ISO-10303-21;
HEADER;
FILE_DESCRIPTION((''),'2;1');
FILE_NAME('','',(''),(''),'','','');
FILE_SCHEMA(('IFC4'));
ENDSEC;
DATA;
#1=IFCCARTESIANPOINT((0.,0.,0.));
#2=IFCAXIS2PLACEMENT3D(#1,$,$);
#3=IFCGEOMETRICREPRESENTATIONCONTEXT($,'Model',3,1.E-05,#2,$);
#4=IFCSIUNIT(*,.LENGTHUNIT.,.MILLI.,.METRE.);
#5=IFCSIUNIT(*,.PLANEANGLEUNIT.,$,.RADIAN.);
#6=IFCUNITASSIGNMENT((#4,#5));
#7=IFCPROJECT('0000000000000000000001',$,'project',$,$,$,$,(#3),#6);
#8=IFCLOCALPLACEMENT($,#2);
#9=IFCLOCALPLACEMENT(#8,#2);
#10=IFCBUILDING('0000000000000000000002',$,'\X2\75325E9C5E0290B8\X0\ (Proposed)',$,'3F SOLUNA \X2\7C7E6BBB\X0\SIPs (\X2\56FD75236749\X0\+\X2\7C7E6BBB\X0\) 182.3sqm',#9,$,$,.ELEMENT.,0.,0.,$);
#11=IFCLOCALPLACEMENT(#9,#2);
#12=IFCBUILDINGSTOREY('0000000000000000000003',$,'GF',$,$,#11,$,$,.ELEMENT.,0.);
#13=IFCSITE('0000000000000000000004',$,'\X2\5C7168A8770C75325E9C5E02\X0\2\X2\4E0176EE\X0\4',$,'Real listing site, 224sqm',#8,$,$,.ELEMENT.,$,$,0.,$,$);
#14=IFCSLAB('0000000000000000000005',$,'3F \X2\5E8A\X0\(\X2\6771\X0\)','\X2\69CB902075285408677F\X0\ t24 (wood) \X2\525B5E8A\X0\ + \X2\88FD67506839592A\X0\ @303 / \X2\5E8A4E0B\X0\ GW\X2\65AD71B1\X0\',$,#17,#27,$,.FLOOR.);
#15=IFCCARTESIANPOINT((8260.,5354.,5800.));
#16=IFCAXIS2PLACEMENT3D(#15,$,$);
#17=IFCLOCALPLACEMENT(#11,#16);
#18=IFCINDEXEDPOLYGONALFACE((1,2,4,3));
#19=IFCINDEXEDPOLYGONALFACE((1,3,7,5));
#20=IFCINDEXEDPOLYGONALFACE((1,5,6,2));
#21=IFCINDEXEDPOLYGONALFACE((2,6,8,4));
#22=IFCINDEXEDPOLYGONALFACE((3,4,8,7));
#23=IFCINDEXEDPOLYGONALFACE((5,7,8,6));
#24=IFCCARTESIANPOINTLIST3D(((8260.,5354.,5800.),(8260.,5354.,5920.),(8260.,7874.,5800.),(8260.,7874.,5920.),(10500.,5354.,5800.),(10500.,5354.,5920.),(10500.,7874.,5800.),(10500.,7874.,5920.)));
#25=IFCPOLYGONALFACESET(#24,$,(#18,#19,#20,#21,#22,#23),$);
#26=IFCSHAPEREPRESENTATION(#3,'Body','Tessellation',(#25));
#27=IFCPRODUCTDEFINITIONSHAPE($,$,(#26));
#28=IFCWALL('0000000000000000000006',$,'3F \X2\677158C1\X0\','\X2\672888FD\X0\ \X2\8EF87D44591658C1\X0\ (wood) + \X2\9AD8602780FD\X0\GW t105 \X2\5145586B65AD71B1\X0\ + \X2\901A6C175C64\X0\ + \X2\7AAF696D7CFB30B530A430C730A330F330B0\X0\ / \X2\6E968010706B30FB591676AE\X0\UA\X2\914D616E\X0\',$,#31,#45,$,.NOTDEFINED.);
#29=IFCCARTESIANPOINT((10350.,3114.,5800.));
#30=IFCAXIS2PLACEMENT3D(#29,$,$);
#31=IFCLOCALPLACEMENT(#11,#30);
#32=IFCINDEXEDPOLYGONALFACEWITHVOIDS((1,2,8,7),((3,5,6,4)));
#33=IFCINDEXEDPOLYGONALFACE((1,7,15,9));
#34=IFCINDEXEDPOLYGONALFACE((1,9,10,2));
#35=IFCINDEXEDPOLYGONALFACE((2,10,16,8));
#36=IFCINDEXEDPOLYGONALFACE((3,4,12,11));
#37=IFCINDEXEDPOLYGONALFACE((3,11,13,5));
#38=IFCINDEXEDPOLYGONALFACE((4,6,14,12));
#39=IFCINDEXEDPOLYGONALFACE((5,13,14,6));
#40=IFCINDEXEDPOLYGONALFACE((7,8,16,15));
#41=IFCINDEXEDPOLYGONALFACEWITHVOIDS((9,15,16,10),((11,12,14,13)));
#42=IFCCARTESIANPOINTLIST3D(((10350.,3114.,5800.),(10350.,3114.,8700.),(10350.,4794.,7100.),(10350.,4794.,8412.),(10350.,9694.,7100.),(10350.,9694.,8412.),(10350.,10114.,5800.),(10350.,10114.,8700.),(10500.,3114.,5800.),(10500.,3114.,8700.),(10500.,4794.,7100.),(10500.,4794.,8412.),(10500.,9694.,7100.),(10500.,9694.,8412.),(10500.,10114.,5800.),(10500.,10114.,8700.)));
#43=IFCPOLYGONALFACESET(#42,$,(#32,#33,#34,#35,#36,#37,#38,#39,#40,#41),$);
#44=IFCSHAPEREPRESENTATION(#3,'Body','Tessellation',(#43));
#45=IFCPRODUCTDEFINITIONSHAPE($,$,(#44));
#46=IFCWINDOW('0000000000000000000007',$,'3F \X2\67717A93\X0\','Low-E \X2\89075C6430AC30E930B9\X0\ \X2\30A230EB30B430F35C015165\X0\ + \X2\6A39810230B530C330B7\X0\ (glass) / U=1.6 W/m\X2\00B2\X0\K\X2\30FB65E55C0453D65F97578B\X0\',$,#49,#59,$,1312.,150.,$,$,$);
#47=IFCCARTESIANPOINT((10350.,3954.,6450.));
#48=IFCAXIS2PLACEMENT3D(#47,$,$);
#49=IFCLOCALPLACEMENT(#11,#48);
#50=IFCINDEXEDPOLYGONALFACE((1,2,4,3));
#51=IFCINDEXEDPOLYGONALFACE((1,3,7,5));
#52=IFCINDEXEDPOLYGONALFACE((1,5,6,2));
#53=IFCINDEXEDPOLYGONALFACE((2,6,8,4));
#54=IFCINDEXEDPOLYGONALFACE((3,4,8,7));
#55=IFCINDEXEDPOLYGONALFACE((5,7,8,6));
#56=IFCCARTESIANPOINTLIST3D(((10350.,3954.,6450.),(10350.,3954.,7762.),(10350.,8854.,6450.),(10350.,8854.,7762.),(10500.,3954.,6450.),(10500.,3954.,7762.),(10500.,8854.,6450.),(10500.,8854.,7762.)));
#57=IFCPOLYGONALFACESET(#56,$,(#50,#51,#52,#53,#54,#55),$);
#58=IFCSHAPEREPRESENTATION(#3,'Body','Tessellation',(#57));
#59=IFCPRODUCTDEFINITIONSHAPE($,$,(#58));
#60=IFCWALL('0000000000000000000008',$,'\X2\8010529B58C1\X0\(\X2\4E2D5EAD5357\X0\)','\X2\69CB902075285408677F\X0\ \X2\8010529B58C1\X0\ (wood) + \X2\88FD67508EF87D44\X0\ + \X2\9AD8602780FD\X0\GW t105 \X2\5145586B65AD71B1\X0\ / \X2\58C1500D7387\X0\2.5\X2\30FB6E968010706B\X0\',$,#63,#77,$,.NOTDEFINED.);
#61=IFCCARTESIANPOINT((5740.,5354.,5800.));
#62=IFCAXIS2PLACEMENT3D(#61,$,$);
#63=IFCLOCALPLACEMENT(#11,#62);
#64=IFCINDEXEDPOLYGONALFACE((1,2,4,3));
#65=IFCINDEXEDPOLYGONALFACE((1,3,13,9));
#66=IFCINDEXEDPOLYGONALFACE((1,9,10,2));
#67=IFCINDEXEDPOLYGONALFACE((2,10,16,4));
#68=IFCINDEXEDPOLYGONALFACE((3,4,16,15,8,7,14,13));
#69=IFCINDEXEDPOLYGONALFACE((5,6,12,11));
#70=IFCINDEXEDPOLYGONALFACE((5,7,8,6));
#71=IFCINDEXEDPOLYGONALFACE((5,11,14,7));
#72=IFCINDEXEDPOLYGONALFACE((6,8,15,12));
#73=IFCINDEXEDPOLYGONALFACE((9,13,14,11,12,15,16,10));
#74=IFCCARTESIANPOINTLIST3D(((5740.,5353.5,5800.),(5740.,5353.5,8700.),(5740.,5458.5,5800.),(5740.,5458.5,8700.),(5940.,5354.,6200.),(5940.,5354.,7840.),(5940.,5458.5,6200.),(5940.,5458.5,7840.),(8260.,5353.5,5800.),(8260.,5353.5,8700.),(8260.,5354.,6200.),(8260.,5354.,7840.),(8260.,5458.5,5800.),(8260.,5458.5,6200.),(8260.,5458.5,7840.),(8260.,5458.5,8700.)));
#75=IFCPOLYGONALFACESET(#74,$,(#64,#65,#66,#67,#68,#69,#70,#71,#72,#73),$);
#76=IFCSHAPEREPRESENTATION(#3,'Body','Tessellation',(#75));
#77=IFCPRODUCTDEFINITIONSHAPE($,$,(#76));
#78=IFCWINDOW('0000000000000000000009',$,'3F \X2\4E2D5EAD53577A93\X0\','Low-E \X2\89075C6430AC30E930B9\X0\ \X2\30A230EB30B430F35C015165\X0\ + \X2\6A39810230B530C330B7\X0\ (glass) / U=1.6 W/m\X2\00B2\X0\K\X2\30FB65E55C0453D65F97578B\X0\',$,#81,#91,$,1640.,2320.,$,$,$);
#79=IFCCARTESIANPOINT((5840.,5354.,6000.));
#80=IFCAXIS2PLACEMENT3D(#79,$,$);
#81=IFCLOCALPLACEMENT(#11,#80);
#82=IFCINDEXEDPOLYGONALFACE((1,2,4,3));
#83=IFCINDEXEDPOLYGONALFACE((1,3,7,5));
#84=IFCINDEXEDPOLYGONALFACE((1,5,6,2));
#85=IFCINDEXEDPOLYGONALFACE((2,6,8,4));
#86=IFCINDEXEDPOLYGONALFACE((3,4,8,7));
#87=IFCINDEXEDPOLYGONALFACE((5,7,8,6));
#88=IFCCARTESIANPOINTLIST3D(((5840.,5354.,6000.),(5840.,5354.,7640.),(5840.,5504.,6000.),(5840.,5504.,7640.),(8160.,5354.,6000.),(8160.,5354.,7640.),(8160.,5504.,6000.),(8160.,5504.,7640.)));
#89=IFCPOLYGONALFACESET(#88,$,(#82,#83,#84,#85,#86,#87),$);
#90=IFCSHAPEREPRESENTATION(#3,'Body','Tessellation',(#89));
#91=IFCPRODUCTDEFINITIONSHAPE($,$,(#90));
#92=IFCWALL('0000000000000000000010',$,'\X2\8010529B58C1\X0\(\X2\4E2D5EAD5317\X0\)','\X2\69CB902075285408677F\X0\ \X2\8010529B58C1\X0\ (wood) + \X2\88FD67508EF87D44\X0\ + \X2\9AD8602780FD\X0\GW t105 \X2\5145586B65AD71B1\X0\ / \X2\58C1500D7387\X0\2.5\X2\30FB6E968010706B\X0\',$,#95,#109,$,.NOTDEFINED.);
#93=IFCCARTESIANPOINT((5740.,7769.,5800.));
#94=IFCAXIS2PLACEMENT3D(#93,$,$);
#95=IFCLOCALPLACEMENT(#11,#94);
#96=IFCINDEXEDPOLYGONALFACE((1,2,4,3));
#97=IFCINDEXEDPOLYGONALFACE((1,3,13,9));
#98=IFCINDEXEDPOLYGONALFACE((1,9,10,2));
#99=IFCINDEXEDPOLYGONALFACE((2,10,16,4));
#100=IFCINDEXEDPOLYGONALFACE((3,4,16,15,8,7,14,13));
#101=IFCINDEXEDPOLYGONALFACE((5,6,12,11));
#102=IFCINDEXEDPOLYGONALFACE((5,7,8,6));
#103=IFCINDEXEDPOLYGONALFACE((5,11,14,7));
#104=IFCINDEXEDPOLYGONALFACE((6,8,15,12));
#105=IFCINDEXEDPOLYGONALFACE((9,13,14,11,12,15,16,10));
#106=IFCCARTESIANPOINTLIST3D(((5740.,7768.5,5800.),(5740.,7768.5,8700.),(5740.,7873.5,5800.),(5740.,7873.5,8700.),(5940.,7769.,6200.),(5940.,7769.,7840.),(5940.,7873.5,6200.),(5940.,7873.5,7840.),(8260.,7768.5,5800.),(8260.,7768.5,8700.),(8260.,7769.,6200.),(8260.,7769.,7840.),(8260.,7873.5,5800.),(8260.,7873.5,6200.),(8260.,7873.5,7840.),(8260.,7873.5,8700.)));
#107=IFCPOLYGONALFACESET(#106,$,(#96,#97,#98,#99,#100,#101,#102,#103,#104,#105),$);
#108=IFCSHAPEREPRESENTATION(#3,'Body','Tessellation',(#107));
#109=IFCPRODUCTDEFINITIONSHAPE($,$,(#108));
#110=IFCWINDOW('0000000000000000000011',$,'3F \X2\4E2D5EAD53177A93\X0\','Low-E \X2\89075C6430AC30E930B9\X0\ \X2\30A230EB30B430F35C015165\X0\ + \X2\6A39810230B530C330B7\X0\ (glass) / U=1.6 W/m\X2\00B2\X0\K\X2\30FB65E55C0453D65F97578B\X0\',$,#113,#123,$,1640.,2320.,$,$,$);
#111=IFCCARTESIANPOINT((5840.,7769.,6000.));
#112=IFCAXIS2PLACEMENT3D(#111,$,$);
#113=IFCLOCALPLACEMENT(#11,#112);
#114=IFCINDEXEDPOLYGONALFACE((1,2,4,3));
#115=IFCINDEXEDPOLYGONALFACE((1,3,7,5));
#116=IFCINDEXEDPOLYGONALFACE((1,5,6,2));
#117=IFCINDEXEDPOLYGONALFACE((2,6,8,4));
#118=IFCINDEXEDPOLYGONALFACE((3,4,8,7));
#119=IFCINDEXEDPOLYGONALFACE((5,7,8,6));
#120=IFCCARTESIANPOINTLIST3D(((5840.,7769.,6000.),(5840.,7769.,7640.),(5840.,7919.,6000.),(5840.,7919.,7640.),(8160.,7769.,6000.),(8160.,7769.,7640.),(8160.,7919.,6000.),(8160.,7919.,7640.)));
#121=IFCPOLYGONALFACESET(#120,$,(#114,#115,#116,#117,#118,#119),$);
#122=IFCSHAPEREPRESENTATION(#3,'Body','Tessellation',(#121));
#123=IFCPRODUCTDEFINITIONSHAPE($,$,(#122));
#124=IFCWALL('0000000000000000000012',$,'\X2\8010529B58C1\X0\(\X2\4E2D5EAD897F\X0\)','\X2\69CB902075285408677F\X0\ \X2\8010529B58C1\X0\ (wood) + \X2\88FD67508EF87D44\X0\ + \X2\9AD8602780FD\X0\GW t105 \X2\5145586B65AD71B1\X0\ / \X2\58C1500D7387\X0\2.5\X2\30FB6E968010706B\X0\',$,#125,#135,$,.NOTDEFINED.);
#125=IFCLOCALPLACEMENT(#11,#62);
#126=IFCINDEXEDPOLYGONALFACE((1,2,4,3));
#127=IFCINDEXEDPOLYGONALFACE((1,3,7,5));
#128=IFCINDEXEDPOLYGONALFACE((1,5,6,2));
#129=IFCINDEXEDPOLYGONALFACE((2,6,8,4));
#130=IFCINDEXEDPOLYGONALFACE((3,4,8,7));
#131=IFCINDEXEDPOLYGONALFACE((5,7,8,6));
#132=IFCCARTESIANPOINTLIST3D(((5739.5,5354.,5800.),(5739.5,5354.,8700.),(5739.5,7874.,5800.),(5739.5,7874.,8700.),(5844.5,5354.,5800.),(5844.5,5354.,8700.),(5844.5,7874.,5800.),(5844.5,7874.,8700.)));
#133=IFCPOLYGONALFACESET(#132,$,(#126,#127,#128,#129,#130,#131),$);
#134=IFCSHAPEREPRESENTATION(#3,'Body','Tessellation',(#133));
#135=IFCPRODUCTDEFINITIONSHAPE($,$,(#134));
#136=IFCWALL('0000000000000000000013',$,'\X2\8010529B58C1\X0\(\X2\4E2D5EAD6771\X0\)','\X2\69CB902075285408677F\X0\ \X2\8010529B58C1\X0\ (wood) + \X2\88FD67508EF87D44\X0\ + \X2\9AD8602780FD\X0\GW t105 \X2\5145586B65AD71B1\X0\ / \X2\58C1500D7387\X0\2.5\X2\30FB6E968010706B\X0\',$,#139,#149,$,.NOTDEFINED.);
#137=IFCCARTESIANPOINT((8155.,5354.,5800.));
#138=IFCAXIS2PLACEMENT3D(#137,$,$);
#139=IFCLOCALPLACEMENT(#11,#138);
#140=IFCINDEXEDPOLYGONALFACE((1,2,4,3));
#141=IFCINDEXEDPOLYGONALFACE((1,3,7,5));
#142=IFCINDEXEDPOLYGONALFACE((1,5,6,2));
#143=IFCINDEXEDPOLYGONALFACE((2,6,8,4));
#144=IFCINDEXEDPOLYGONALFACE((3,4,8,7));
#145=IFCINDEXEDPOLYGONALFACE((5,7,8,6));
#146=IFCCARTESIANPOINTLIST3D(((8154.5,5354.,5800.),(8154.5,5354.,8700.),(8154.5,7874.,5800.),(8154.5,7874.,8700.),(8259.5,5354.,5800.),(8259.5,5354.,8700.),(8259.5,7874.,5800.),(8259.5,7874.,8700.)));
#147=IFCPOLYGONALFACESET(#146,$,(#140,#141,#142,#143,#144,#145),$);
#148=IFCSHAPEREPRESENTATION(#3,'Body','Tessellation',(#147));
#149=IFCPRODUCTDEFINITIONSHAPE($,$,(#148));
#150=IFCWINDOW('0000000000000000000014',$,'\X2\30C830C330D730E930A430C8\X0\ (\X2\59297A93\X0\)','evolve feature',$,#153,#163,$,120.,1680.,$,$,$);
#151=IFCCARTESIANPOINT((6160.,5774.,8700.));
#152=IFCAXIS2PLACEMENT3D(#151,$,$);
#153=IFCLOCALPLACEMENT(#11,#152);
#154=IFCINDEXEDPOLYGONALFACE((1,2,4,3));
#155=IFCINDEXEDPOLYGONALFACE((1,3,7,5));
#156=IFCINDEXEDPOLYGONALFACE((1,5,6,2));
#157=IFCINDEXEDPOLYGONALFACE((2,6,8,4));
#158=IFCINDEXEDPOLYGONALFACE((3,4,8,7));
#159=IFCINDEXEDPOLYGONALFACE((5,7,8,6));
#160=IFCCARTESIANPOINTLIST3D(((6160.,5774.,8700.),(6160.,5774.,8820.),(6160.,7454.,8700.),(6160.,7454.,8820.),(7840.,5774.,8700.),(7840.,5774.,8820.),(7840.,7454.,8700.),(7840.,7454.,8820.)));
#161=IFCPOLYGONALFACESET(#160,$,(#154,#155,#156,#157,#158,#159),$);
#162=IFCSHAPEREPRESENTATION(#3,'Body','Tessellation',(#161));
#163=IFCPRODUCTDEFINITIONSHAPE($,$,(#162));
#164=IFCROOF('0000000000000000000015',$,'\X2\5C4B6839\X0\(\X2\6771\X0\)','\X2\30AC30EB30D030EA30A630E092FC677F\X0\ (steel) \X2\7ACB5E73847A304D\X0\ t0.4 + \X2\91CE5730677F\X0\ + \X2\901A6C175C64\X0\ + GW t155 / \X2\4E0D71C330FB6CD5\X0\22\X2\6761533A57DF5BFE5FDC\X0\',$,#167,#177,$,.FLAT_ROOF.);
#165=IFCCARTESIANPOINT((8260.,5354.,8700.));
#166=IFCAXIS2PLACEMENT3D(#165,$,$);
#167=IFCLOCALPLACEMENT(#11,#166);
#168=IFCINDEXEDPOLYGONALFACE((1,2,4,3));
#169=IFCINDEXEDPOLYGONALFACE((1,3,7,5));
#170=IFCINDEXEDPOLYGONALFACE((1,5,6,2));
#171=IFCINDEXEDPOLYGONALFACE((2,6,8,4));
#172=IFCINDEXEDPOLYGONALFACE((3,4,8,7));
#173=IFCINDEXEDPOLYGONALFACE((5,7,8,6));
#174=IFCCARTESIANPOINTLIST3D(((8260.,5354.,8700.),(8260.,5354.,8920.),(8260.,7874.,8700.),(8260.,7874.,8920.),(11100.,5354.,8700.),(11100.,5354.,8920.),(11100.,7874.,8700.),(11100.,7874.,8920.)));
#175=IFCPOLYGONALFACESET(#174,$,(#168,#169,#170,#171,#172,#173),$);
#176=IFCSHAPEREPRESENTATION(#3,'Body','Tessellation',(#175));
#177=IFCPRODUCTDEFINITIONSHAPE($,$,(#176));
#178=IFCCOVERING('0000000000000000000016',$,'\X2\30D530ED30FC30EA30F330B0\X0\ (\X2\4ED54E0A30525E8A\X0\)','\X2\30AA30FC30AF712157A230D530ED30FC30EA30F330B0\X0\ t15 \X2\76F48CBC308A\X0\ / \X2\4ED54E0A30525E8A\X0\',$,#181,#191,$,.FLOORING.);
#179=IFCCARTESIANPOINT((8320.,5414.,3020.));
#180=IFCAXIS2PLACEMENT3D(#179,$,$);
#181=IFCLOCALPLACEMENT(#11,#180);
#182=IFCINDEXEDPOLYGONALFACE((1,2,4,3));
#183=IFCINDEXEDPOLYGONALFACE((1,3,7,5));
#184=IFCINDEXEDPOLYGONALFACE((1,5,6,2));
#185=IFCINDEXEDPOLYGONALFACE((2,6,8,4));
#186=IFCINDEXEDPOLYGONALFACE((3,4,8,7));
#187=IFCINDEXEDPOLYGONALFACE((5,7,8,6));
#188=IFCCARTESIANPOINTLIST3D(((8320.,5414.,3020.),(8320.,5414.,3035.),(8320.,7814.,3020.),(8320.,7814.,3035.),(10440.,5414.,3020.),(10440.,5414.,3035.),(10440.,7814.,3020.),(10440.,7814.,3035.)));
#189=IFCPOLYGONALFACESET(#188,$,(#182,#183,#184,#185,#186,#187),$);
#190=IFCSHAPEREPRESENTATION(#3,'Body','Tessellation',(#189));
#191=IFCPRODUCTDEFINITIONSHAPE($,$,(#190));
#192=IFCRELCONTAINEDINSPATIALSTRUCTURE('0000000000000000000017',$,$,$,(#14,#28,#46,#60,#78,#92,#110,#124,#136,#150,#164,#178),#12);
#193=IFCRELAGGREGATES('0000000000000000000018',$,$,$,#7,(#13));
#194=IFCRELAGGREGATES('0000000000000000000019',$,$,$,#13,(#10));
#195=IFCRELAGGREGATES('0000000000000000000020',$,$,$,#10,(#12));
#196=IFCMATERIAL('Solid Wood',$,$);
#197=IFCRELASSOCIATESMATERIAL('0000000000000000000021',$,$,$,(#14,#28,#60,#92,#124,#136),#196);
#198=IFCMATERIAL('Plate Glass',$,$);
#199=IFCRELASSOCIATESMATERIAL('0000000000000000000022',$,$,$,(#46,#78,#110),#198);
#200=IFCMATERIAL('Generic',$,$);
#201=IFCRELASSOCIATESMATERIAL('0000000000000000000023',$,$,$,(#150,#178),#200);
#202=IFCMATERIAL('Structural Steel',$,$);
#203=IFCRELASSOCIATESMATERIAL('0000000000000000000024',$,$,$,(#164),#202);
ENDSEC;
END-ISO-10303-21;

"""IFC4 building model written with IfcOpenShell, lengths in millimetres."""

from ifc_helpers import new_model, si_unit, frame, frame_2d, origin, place, context, project, spatial, rectangle, extrude, material, element, fill, save


model = new_model("IFC4")

# Units and contexts
model_context = context("Model", 3, precision=1e-05, world=origin())
ifc_project = project(units=[si_unit("LENGTHUNIT", "METRE", prefix="MILLI"), si_unit("PLANEANGLEUNIT", "RADIAN")], contexts=[model_context])

# Site, building, storey
site_placement = place(None, origin())
site = spatial("IfcSite", under=ifc_project, at=site_placement, Name="山梨県甲府市2丁目4", ObjectType="Real listing site, 224sqm", CompositionType="ELEMENT", RefElevation=0.0)
building_placement = place(site_placement, origin())
building = spatial("IfcBuilding", under=site, at=building_placement, Name="甲府市邸 (Proposed)", ObjectType="3F SOLUNA 籾殻SIPs (国産杉+籾殻) 182.3sqm", CompositionType="ELEMENT", ElevationOfRefHeight=0.0, ElevationOfTerrain=0.0)
storey_placement = place(building_placement, origin())
storey = spatial("IfcBuildingStorey", under=building, at=storey_placement, Name="GF", CompositionType="ELEMENT", Elevation=0.0)

# Slab
ifc_material_1 = material(Name="Solid Wood")
slab_placement = place(storey_placement, frame((8260.0, 5354.0, 5800.0)))
element("IfcSlab", 1, at=slab_placement, inside=storey, material=ifc_material_1, Name="3F 床(東)", Description="構造用合板 t24 (wood) 剛床 + 製材根太 @303 / 床下 GW断熱", PredefinedType="FLOOR", context=model_context, shape_type="SweptSolid", body=[
    extrude(rectangle(XDim=2240.0, YDim=2520.0, at=frame_2d((1120.0, 1260.0))), frame((8260.0, 5354.0, 5800.0)), (0.0, 0.0, 1.0), 120.0),
])

# Walls, openings, windows
wall_1_placement = place(storey_placement, frame((10350.0, 3114.0, 5800.0)))
wall_1 = element("IfcWall", 2, at=wall_1_placement, inside=storey, material=ifc_material_1, Name="3F 東壁", Description="木製 軸組外壁 (wood) + 高性能GW t105 充填断熱 + 通気層 + 窯業系サイディング / 準耐火・外皮UA配慮", PredefinedType="NOTDEFINED", context=model_context, shape_type="SweptSolid", body=[
    extrude(rectangle(XDim=150.0, YDim=7000.0, at=frame_2d((75.0, 3500.0))), frame((10350.0, 3114.0, 5800.0)), (0.0, 0.0, 1.0), 2900.0),
])
opening_1_placement = place(storey_placement, frame((10350.0, 3954.0, 6450.0)))
opening_1 = element("IfcOpeningElement", 3, at=opening_1_placement, cuts=wall_1, PredefinedType="NOTDEFINED", context=model_context, shape_type="SweptSolid", body=[
    extrude(rectangle(XDim=150.0, YDim=4900.0, at=frame_2d((75.0, 2450.0))), frame((10350.0, 3954.0, 6450.0)), (0.0, 0.0, 1.0), 1312.0),
])
ifc_material_2 = material(Name="Plate Glass")
window_1_placement = place(storey_placement, frame((10350.0, 3954.0, 6450.0)))
window_1 = element("IfcWindow", 4, at=window_1_placement, inside=storey, material=ifc_material_2, Name="3F 東窓", Description="Low-E 複層ガラス アルゴン封入 + 樹脂サッシ (glass) / U=1.6 W/m²K・日射取得型", OverallHeight=1312.0, OverallWidth=150.0, context=model_context, shape_type="SweptSolid", body=[
    extrude(rectangle(XDim=150.0, YDim=4900.0, at=frame_2d((75.0, 2450.0))), frame((10350.0, 3954.0, 6450.0)), (0.0, 0.0, 1.0), 1312.0),
])
fill(opening_1, window_1)
wall_2_placement = place(storey_placement, frame((5740.0, 5354.0, 5800.0)))
wall_2 = element("IfcWall", 5, at=wall_2_placement, inside=storey, material=ifc_material_1, Name="耐力壁(中庭南)", Description="構造用合板 耐力壁 (wood) + 製材軸組 + 高性能GW t105 充填断熱 / 壁倍率2.5・準耐火", PredefinedType="NOTDEFINED", context=model_context, shape_type="SweptSolid", body=[
    extrude(rectangle(XDim=2520.0, YDim=105.0, at=frame_2d((1260.0, 52.0))), frame((5740.0, 5354.0, 5800.0)), (0.0, 0.0, 1.0), 2900.0),
])
opening_2_placement = place(storey_placement, frame((5840.0, 5354.0, 6000.0)))
opening_2 = element("IfcOpeningElement", 6, at=opening_2_placement, cuts=wall_2, PredefinedType="NOTDEFINED", context=model_context, shape_type="SweptSolid", body=[
    extrude(rectangle(XDim=2320.0, YDim=150.0, at=frame_2d((1160.0, 75.0))), frame((5840.0, 5354.0, 6000.0)), (0.0, 0.0, 1.0), 1640.0),
])
window_2_placement = place(storey_placement, frame((5840.0, 5354.0, 6000.0)))
window_2 = element("IfcWindow", 7, at=window_2_placement, inside=storey, material=ifc_material_2, Name="3F 中庭南窓", Description="Low-E 複層ガラス アルゴン封入 + 樹脂サッシ (glass) / U=1.6 W/m²K・日射取得型", OverallHeight=1640.0, OverallWidth=2320.0, context=model_context, shape_type="SweptSolid", body=[
    extrude(rectangle(XDim=2320.0, YDim=150.0, at=frame_2d((1160.0, 75.0))), frame((5840.0, 5354.0, 6000.0)), (0.0, 0.0, 1.0), 1640.0),
])
fill(opening_2, window_2)
wall_3_placement = place(storey_placement, frame((5740.0, 7769.0, 5800.0)))
wall_3 = element("IfcWall", 8, at=wall_3_placement, inside=storey, material=ifc_material_1, Name="耐力壁(中庭北)", Description="構造用合板 耐力壁 (wood) + 製材軸組 + 高性能GW t105 充填断熱 / 壁倍率2.5・準耐火", PredefinedType="NOTDEFINED", context=model_context, shape_type="SweptSolid", body=[
    extrude(rectangle(XDim=2520.0, YDim=105.0, at=frame_2d((1260.0, 52.0))), frame((5740.0, 7769.0, 5800.0)), (0.0, 0.0, 1.0), 2900.0),
])
opening_3_placement = place(storey_placement, frame((5840.0, 7769.0, 6000.0)))
opening_3 = element("IfcOpeningElement", 9, at=opening_3_placement, cuts=wall_3, PredefinedType="NOTDEFINED", context=model_context, shape_type="SweptSolid", body=[
    extrude(rectangle(XDim=2320.0, YDim=150.0, at=frame_2d((1160.0, 75.0))), frame((5840.0, 7769.0, 6000.0)), (0.0, 0.0, 1.0), 1640.0),
])
window_3_placement = place(storey_placement, frame((5840.0, 7769.0, 6000.0)))
window_3 = element("IfcWindow", 10, at=window_3_placement, inside=storey, material=ifc_material_2, Name="3F 中庭北窓", Description="Low-E 複層ガラス アルゴン封入 + 樹脂サッシ (glass) / U=1.6 W/m²K・日射取得型", OverallHeight=1640.0, OverallWidth=2320.0, context=model_context, shape_type="SweptSolid", body=[
    extrude(rectangle(XDim=2320.0, YDim=150.0, at=frame_2d((1160.0, 75.0))), frame((5840.0, 7769.0, 6000.0)), (0.0, 0.0, 1.0), 1640.0),
])
fill(opening_3, window_3)

# Walls
wall_4_placement = place(storey_placement, frame((5740.0, 5354.0, 5800.0)))
element("IfcWall", 11, at=wall_4_placement, inside=storey, material=ifc_material_1, Name="耐力壁(中庭西)", Description="構造用合板 耐力壁 (wood) + 製材軸組 + 高性能GW t105 充填断熱 / 壁倍率2.5・準耐火", PredefinedType="NOTDEFINED", context=model_context, shape_type="SweptSolid", body=[
    extrude(rectangle(XDim=105.0, YDim=2520.0, at=frame_2d((52.0, 1260.0))), frame((5740.0, 5354.0, 5800.0)), (0.0, 0.0, 1.0), 2900.0),
])
wall_5_placement = place(storey_placement, frame((8155.0, 5354.0, 5800.0)))
element("IfcWall", 12, at=wall_5_placement, inside=storey, material=ifc_material_1, Name="耐力壁(中庭東)", Description="構造用合板 耐力壁 (wood) + 製材軸組 + 高性能GW t105 充填断熱 / 壁倍率2.5・準耐火", PredefinedType="NOTDEFINED", context=model_context, shape_type="SweptSolid", body=[
    extrude(rectangle(XDim=105.0, YDim=2520.0, at=frame_2d((52.0, 1260.0))), frame((8155.0, 5354.0, 5800.0)), (0.0, 0.0, 1.0), 2900.0),
])

# Window
ifc_material_3 = material(Name="Generic")
window_4_placement = place(storey_placement, frame((6160.0, 5774.0, 8700.0)))
element("IfcWindow", 13, at=window_4_placement, inside=storey, material=ifc_material_3, Name="トップライト (天窓)", Description="evolve feature", OverallHeight=120.0, OverallWidth=1680.0, context=model_context, shape_type="SweptSolid", body=[
    extrude(rectangle(XDim=1680.0, YDim=1680.0, at=frame_2d((840.0, 840.0))), frame((6160.0, 5774.0, 8700.0)), (0.0, 0.0, 1.0), 120.0),
])

# Roof
ifc_material_4 = material(Name="Structural Steel")
for number, where, name in (
    (14, (8260.0, 5354.0, 8700.0), "屋根(東)"),
):
    element("IfcRoof", number, at=place(storey_placement, frame(where)), inside=storey, material=ifc_material_4, Name=name, Description="ガルバリウム鋼板 (steel) 立平葺き t0.4 + 野地板 + 通気層 + GW t155 / 不燃・法22条区域対応", PredefinedType="FLAT_ROOF", context=model_context, shape_type="SweptSolid", body=[
        extrude(rectangle(XDim=2840.0, YDim=2520.0, at=frame_2d((1420.0, 1260.0))), frame((8260.0, 5354.0, 8700.0)), (0.0, 0.0, 1.0), 220.0),
    ])

# Covering
covering_1_placement = place(storey_placement, frame((8320.0, 5414.0, 3020.0)))
element("IfcCovering", 15, at=covering_1_placement, inside=storey, material=ifc_material_3, Name="フローリング (仕上げ床)", Description="オーク無垢フローリング t15 直貼り / 仕上げ床", PredefinedType="FLOORING", context=model_context, shape_type="SweptSolid", body=[
    extrude(rectangle(XDim=2120.0, YDim=2400.0, at=frame_2d((1060.0, 1200.0))), frame((8320.0, 5414.0, 3020.0)), (0.0, 0.0, 1.0), 15.0),
])

save(model, "model.ifc")
